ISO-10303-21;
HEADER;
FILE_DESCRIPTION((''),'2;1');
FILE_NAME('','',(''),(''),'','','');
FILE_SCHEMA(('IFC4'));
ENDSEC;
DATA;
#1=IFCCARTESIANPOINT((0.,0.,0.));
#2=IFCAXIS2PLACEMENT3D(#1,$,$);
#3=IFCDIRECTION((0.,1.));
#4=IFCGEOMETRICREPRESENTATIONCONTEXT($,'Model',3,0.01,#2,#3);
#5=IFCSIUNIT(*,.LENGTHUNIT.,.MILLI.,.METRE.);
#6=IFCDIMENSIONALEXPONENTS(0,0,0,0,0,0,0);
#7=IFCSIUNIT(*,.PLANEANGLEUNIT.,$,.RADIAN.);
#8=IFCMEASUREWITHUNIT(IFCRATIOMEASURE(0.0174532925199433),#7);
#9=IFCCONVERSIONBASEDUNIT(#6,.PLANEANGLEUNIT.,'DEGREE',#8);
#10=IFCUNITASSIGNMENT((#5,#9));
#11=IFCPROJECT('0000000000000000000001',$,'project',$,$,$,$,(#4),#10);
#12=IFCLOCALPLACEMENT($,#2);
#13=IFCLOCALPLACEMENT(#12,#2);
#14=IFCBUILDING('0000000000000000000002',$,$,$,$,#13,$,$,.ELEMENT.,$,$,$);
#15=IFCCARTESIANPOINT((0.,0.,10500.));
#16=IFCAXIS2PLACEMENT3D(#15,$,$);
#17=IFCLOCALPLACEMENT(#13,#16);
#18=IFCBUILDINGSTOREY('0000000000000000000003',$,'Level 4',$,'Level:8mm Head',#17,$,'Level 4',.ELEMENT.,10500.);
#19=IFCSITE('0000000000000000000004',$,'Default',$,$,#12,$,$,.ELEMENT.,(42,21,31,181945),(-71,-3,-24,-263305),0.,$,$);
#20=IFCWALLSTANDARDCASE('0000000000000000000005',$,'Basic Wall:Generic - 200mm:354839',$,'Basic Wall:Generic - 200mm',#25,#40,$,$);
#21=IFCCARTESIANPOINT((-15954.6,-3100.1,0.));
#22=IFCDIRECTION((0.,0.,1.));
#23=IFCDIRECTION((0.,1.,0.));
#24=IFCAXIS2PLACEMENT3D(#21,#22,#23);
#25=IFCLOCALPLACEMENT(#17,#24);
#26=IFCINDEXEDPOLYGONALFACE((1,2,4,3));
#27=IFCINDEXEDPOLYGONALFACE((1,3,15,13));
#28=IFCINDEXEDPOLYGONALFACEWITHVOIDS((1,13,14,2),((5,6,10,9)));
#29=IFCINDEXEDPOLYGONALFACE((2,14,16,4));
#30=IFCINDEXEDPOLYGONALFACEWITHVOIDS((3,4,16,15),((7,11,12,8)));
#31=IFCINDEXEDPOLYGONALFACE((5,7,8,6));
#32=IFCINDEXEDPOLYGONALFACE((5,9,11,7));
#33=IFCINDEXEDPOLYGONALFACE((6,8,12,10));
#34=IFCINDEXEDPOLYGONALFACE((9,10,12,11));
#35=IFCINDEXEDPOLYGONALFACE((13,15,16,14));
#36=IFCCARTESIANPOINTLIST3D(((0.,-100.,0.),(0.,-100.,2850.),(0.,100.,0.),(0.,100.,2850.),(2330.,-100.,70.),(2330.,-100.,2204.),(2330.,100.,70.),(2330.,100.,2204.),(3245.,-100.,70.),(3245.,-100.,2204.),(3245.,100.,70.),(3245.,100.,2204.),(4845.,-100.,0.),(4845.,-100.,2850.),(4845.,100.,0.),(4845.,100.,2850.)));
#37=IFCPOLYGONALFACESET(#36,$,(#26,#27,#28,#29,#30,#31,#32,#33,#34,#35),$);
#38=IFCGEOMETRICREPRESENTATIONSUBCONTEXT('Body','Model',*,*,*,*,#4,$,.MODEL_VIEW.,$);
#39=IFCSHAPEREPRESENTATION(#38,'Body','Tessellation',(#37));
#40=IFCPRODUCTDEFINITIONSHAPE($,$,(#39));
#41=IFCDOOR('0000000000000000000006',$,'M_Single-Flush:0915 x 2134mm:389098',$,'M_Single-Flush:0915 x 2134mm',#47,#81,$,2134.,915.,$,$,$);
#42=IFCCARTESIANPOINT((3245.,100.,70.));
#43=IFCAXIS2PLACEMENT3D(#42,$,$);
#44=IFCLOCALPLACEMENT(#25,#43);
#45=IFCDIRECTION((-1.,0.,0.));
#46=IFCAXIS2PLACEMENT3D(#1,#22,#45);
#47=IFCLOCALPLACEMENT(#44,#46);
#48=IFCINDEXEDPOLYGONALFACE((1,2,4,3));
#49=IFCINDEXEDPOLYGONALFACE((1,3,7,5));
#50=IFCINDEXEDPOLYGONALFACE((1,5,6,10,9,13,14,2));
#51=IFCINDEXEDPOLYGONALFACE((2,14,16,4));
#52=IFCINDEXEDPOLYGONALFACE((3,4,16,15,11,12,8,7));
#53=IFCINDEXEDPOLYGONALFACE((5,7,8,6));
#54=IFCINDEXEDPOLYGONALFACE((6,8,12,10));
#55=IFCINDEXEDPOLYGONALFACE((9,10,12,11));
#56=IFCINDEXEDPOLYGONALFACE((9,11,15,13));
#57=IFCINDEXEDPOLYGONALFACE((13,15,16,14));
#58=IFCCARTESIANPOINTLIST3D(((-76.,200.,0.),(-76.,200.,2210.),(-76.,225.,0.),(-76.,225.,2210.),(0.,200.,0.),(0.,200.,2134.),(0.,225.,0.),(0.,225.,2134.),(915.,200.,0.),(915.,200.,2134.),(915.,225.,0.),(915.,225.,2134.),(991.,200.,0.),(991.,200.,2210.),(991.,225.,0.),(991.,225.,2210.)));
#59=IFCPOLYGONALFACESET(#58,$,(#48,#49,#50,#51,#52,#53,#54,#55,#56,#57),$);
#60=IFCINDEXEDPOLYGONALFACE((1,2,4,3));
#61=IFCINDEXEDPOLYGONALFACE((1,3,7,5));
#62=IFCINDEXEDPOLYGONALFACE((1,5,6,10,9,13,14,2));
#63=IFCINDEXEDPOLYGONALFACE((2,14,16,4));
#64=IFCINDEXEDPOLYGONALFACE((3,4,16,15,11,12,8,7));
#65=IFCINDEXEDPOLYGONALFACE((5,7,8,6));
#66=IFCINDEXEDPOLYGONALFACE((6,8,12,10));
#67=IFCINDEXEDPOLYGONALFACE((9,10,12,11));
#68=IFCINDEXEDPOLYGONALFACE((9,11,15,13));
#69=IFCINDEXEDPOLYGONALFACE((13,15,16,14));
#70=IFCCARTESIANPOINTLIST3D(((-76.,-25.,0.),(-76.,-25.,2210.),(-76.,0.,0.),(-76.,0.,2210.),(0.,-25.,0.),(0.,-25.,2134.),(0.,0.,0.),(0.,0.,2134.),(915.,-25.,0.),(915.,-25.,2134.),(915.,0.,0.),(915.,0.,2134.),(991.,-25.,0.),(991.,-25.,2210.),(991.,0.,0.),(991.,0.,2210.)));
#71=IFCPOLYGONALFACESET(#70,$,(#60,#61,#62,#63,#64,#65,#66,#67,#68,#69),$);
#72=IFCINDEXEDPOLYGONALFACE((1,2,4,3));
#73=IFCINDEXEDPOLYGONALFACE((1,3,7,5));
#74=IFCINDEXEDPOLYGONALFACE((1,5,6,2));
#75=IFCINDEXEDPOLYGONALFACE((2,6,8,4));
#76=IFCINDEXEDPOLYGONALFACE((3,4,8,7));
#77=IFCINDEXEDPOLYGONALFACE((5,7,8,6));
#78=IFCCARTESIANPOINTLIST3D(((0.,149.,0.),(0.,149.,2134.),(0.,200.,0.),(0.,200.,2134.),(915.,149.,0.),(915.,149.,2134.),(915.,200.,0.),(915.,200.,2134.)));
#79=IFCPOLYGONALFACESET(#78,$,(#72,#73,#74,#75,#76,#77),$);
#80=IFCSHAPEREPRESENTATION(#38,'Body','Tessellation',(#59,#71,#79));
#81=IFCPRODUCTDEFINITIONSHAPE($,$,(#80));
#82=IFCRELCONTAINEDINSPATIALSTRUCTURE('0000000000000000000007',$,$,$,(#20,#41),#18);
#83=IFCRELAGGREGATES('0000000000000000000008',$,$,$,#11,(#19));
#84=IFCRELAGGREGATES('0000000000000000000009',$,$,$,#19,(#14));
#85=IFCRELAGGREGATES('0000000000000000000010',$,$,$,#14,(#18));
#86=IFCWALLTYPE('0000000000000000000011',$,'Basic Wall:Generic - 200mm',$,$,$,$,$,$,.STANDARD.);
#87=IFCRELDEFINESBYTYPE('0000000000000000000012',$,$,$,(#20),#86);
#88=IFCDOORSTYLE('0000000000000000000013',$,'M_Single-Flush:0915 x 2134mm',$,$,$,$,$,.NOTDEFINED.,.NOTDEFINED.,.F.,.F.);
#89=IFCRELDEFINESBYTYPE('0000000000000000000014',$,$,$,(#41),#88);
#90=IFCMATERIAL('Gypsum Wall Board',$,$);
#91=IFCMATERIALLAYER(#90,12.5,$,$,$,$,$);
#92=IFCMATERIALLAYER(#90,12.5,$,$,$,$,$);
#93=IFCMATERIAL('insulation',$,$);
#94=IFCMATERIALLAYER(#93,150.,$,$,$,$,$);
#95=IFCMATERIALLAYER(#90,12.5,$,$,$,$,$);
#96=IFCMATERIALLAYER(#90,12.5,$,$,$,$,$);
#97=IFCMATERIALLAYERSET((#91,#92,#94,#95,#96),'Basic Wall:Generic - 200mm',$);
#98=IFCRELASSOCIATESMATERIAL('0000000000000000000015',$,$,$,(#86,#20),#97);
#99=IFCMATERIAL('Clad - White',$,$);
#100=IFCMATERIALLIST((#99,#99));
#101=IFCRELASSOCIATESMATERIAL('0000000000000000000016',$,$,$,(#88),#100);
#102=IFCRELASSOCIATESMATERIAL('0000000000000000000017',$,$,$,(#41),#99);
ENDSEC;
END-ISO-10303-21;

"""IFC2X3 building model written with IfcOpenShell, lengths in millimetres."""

from ifc_helpers import new_model, entity, si_unit, converted_unit, direction, frame, frame_2d, origin, place, context, subcontext, project, spatial, polyline, rectangle, outline, extrude, source, transform, mapped, material, material_list, layer, layer_set, layer_usage, type_object, type_shapes, element, fill, save


model = new_model("IFC2X3")

# Units and contexts
model_context = context("Model", 3, precision=0.01, world=origin(), true_north=direction((0.0, 1.0)))
body_context = subcontext(model_context, "Body", "Model", "MODEL_VIEW")
ifc_project = project(units=[si_unit("LENGTHUNIT", "METRE", prefix="MILLI"), converted_unit("PLANEANGLEUNIT", "DEGREE", entity("IfcRatioMeasure", 0.0174532925199433), si_unit("PLANEANGLEUNIT", "RADIAN"), dimensions=[0, 0, 0, 0, 0, 0, 0])], contexts=[model_context])

# Site, building, storey
site_placement = place(None, frame((0.0, 0.0, 0.0)))
site = spatial("IfcSite", under=ifc_project, at=site_placement, Name="Default", CompositionType="ELEMENT", RefLatitude=(42, 21, 31, 181945), RefLongitude=(-71, -3, -24, -263305), RefElevation=0.0)
building_placement = place(site_placement, origin())
building = spatial("IfcBuilding", under=site, at=building_placement, CompositionType="ELEMENT")
storey_placement = place(building_placement, frame((0.0, 0.0, 10500.0)))
storey = spatial("IfcBuildingStorey", under=building, at=storey_placement, Name="Level 4", ObjectType="Level:8mm Head", LongName="Level 4", CompositionType="ELEMENT", Elevation=10500.0)

# Wall, opening, door
ifc_material_1 = material(Name="Gypsum Wall Board")
ifc_layer_1 = layer(ifc_material_1, 12.5)
ifc_layer_2 = layer(ifc_material_1, 12.5)
ifc_material_2 = material(Name="insulation")
ifc_layer_3 = layer(ifc_material_2, 150.0)
ifc_layer_4 = layer(ifc_material_1, 12.5)
ifc_layer_5 = layer(ifc_material_1, 12.5)
ifc_layer_set = layer_set([ifc_layer_1, ifc_layer_2, ifc_layer_3, ifc_layer_4, ifc_layer_5], Name="Basic Wall:Generic - 200mm")
ifc_layer_usage_1 = layer_usage(ifc_layer_set, "AXIS2", "NEGATIVE", 100.0)
wall_type = type_object("IfcWallType", Name="Basic Wall:Generic - 200mm", PredefinedType="STANDARD", material=ifc_layer_set)
wall_1_placement = place(storey_placement, frame((-15954.6, -3100.1, 0.0), z_axis=(0.0, 0.0, 1.0), x_axis=(0.0, 1.0, 0.0)))
wall_1 = element("IfcWallStandardCase", 1, at=wall_1_placement, inside=storey, type_object=wall_type, material=ifc_layer_usage_1, Name="Basic Wall:Generic - 200mm:354839", ObjectType="Basic Wall:Generic - 200mm", context=body_context, shape_type="SweptSolid", body=[
    extrude(rectangle(XDim=4845.0, YDim=200.0, at=frame_2d((2422.5, 0.0), x_axis=(-1.0, 0.0))), origin(), (0.0, 0.0, 1.0), 2850.0),
])
opening_placement = place(wall_1_placement, frame((3245.0, 100.0, 70.0)))
opening = element("IfcOpeningElement", 2, at=opening_placement, cuts=wall_1, ObjectType="Opening", context=body_context, shape_type="SweptSolid", body=[
    extrude(rectangle(XDim=915.0, YDim=2134.0, at=frame_2d((1067.0, 457.5), x_axis=(0.0, 1.0))), frame((0.0, 0.0, 0.0), z_axis=(0.0, -1.0, 0.0), x_axis=(0.0, 0.0, 1.0)), (0.0, 0.0, 1.0), 200.0),
])
ifc_material_3 = material(Name="Clad - White")
ifc_material_list = material_list([ifc_material_3, ifc_material_3])
door_style = type_object("IfcDoorStyle", Name="M_Single-Flush:0915 x 2134mm", ConstructionType="NOTDEFINED", OperationType="NOTDEFINED", ParameterTakesPrecedence=False, Sizeable=False, material=ifc_material_list)
shared_shape_1 = source(origin(), body_context, "Body", "SweptSolid", [
    extrude(outline(polyline([(-533.5, -1124.0), (533.5, -1124.0), (533.5, 1086.0), (457.5, 1086.0), (457.5, -1048.0), (-457.5, -1048.0), (-457.5, 1086.0), (-533.5, 1086.0), (-533.5, -1124.0)])), frame((457.5, 200.0, 1086.0), z_axis=(0.0, 1.0, 0.0), x_axis=(1.0, 0.0, 0.0)), (0.0, 0.0, 1.0), 25.0),
    extrude(outline(polyline([(-1124.0, -533.5), (1086.0, -533.5), (1086.0, -457.5), (-1048.0, -457.5), (-1048.0, 457.5), (1086.0, 457.5), (1086.0, 533.5), (-1124.0, 533.5), (-1124.0, -533.5)])), frame((457.5, -25.0, 1086.0), z_axis=(0.0, 1.0, 0.0), x_axis=(0.0, 0.0, -1.0)), (0.0, 0.0, 1.0), 25.0),
    extrude(rectangle(XDim=51.0, YDim=915.0, at=frame_2d((0.0, 0.0), x_axis=(1.0, 0.0))), frame((457.5, 174.5, 0.0), z_axis=(0.0, 0.0, 1.0), x_axis=(0.0, 1.0, 0.0)), (0.0, 0.0, 1.0), 2134.0),
])
type_shapes(door_style, [shared_shape_1])
door_placement = place(opening_placement, frame((0.0, 0.0, 0.0), z_axis=(0.0, 0.0, 1.0), x_axis=(-1.0, 0.0, 0.0)))
door = element("IfcDoor", 3, at=door_placement, inside=storey, type_object=door_style, material=ifc_material_3, Name="M_Single-Flush:0915 x 2134mm:389098", ObjectType="M_Single-Flush:0915 x 2134mm", OverallHeight=2134.0, OverallWidth=915.0, context=body_context, shape_type="MappedRepresentation", body=[
    mapped(shared_shape_1, transform((0.0, 0.0, 0.0), scale=1.0)),
])
fill(opening, door)

save(model, "model.ifc")
